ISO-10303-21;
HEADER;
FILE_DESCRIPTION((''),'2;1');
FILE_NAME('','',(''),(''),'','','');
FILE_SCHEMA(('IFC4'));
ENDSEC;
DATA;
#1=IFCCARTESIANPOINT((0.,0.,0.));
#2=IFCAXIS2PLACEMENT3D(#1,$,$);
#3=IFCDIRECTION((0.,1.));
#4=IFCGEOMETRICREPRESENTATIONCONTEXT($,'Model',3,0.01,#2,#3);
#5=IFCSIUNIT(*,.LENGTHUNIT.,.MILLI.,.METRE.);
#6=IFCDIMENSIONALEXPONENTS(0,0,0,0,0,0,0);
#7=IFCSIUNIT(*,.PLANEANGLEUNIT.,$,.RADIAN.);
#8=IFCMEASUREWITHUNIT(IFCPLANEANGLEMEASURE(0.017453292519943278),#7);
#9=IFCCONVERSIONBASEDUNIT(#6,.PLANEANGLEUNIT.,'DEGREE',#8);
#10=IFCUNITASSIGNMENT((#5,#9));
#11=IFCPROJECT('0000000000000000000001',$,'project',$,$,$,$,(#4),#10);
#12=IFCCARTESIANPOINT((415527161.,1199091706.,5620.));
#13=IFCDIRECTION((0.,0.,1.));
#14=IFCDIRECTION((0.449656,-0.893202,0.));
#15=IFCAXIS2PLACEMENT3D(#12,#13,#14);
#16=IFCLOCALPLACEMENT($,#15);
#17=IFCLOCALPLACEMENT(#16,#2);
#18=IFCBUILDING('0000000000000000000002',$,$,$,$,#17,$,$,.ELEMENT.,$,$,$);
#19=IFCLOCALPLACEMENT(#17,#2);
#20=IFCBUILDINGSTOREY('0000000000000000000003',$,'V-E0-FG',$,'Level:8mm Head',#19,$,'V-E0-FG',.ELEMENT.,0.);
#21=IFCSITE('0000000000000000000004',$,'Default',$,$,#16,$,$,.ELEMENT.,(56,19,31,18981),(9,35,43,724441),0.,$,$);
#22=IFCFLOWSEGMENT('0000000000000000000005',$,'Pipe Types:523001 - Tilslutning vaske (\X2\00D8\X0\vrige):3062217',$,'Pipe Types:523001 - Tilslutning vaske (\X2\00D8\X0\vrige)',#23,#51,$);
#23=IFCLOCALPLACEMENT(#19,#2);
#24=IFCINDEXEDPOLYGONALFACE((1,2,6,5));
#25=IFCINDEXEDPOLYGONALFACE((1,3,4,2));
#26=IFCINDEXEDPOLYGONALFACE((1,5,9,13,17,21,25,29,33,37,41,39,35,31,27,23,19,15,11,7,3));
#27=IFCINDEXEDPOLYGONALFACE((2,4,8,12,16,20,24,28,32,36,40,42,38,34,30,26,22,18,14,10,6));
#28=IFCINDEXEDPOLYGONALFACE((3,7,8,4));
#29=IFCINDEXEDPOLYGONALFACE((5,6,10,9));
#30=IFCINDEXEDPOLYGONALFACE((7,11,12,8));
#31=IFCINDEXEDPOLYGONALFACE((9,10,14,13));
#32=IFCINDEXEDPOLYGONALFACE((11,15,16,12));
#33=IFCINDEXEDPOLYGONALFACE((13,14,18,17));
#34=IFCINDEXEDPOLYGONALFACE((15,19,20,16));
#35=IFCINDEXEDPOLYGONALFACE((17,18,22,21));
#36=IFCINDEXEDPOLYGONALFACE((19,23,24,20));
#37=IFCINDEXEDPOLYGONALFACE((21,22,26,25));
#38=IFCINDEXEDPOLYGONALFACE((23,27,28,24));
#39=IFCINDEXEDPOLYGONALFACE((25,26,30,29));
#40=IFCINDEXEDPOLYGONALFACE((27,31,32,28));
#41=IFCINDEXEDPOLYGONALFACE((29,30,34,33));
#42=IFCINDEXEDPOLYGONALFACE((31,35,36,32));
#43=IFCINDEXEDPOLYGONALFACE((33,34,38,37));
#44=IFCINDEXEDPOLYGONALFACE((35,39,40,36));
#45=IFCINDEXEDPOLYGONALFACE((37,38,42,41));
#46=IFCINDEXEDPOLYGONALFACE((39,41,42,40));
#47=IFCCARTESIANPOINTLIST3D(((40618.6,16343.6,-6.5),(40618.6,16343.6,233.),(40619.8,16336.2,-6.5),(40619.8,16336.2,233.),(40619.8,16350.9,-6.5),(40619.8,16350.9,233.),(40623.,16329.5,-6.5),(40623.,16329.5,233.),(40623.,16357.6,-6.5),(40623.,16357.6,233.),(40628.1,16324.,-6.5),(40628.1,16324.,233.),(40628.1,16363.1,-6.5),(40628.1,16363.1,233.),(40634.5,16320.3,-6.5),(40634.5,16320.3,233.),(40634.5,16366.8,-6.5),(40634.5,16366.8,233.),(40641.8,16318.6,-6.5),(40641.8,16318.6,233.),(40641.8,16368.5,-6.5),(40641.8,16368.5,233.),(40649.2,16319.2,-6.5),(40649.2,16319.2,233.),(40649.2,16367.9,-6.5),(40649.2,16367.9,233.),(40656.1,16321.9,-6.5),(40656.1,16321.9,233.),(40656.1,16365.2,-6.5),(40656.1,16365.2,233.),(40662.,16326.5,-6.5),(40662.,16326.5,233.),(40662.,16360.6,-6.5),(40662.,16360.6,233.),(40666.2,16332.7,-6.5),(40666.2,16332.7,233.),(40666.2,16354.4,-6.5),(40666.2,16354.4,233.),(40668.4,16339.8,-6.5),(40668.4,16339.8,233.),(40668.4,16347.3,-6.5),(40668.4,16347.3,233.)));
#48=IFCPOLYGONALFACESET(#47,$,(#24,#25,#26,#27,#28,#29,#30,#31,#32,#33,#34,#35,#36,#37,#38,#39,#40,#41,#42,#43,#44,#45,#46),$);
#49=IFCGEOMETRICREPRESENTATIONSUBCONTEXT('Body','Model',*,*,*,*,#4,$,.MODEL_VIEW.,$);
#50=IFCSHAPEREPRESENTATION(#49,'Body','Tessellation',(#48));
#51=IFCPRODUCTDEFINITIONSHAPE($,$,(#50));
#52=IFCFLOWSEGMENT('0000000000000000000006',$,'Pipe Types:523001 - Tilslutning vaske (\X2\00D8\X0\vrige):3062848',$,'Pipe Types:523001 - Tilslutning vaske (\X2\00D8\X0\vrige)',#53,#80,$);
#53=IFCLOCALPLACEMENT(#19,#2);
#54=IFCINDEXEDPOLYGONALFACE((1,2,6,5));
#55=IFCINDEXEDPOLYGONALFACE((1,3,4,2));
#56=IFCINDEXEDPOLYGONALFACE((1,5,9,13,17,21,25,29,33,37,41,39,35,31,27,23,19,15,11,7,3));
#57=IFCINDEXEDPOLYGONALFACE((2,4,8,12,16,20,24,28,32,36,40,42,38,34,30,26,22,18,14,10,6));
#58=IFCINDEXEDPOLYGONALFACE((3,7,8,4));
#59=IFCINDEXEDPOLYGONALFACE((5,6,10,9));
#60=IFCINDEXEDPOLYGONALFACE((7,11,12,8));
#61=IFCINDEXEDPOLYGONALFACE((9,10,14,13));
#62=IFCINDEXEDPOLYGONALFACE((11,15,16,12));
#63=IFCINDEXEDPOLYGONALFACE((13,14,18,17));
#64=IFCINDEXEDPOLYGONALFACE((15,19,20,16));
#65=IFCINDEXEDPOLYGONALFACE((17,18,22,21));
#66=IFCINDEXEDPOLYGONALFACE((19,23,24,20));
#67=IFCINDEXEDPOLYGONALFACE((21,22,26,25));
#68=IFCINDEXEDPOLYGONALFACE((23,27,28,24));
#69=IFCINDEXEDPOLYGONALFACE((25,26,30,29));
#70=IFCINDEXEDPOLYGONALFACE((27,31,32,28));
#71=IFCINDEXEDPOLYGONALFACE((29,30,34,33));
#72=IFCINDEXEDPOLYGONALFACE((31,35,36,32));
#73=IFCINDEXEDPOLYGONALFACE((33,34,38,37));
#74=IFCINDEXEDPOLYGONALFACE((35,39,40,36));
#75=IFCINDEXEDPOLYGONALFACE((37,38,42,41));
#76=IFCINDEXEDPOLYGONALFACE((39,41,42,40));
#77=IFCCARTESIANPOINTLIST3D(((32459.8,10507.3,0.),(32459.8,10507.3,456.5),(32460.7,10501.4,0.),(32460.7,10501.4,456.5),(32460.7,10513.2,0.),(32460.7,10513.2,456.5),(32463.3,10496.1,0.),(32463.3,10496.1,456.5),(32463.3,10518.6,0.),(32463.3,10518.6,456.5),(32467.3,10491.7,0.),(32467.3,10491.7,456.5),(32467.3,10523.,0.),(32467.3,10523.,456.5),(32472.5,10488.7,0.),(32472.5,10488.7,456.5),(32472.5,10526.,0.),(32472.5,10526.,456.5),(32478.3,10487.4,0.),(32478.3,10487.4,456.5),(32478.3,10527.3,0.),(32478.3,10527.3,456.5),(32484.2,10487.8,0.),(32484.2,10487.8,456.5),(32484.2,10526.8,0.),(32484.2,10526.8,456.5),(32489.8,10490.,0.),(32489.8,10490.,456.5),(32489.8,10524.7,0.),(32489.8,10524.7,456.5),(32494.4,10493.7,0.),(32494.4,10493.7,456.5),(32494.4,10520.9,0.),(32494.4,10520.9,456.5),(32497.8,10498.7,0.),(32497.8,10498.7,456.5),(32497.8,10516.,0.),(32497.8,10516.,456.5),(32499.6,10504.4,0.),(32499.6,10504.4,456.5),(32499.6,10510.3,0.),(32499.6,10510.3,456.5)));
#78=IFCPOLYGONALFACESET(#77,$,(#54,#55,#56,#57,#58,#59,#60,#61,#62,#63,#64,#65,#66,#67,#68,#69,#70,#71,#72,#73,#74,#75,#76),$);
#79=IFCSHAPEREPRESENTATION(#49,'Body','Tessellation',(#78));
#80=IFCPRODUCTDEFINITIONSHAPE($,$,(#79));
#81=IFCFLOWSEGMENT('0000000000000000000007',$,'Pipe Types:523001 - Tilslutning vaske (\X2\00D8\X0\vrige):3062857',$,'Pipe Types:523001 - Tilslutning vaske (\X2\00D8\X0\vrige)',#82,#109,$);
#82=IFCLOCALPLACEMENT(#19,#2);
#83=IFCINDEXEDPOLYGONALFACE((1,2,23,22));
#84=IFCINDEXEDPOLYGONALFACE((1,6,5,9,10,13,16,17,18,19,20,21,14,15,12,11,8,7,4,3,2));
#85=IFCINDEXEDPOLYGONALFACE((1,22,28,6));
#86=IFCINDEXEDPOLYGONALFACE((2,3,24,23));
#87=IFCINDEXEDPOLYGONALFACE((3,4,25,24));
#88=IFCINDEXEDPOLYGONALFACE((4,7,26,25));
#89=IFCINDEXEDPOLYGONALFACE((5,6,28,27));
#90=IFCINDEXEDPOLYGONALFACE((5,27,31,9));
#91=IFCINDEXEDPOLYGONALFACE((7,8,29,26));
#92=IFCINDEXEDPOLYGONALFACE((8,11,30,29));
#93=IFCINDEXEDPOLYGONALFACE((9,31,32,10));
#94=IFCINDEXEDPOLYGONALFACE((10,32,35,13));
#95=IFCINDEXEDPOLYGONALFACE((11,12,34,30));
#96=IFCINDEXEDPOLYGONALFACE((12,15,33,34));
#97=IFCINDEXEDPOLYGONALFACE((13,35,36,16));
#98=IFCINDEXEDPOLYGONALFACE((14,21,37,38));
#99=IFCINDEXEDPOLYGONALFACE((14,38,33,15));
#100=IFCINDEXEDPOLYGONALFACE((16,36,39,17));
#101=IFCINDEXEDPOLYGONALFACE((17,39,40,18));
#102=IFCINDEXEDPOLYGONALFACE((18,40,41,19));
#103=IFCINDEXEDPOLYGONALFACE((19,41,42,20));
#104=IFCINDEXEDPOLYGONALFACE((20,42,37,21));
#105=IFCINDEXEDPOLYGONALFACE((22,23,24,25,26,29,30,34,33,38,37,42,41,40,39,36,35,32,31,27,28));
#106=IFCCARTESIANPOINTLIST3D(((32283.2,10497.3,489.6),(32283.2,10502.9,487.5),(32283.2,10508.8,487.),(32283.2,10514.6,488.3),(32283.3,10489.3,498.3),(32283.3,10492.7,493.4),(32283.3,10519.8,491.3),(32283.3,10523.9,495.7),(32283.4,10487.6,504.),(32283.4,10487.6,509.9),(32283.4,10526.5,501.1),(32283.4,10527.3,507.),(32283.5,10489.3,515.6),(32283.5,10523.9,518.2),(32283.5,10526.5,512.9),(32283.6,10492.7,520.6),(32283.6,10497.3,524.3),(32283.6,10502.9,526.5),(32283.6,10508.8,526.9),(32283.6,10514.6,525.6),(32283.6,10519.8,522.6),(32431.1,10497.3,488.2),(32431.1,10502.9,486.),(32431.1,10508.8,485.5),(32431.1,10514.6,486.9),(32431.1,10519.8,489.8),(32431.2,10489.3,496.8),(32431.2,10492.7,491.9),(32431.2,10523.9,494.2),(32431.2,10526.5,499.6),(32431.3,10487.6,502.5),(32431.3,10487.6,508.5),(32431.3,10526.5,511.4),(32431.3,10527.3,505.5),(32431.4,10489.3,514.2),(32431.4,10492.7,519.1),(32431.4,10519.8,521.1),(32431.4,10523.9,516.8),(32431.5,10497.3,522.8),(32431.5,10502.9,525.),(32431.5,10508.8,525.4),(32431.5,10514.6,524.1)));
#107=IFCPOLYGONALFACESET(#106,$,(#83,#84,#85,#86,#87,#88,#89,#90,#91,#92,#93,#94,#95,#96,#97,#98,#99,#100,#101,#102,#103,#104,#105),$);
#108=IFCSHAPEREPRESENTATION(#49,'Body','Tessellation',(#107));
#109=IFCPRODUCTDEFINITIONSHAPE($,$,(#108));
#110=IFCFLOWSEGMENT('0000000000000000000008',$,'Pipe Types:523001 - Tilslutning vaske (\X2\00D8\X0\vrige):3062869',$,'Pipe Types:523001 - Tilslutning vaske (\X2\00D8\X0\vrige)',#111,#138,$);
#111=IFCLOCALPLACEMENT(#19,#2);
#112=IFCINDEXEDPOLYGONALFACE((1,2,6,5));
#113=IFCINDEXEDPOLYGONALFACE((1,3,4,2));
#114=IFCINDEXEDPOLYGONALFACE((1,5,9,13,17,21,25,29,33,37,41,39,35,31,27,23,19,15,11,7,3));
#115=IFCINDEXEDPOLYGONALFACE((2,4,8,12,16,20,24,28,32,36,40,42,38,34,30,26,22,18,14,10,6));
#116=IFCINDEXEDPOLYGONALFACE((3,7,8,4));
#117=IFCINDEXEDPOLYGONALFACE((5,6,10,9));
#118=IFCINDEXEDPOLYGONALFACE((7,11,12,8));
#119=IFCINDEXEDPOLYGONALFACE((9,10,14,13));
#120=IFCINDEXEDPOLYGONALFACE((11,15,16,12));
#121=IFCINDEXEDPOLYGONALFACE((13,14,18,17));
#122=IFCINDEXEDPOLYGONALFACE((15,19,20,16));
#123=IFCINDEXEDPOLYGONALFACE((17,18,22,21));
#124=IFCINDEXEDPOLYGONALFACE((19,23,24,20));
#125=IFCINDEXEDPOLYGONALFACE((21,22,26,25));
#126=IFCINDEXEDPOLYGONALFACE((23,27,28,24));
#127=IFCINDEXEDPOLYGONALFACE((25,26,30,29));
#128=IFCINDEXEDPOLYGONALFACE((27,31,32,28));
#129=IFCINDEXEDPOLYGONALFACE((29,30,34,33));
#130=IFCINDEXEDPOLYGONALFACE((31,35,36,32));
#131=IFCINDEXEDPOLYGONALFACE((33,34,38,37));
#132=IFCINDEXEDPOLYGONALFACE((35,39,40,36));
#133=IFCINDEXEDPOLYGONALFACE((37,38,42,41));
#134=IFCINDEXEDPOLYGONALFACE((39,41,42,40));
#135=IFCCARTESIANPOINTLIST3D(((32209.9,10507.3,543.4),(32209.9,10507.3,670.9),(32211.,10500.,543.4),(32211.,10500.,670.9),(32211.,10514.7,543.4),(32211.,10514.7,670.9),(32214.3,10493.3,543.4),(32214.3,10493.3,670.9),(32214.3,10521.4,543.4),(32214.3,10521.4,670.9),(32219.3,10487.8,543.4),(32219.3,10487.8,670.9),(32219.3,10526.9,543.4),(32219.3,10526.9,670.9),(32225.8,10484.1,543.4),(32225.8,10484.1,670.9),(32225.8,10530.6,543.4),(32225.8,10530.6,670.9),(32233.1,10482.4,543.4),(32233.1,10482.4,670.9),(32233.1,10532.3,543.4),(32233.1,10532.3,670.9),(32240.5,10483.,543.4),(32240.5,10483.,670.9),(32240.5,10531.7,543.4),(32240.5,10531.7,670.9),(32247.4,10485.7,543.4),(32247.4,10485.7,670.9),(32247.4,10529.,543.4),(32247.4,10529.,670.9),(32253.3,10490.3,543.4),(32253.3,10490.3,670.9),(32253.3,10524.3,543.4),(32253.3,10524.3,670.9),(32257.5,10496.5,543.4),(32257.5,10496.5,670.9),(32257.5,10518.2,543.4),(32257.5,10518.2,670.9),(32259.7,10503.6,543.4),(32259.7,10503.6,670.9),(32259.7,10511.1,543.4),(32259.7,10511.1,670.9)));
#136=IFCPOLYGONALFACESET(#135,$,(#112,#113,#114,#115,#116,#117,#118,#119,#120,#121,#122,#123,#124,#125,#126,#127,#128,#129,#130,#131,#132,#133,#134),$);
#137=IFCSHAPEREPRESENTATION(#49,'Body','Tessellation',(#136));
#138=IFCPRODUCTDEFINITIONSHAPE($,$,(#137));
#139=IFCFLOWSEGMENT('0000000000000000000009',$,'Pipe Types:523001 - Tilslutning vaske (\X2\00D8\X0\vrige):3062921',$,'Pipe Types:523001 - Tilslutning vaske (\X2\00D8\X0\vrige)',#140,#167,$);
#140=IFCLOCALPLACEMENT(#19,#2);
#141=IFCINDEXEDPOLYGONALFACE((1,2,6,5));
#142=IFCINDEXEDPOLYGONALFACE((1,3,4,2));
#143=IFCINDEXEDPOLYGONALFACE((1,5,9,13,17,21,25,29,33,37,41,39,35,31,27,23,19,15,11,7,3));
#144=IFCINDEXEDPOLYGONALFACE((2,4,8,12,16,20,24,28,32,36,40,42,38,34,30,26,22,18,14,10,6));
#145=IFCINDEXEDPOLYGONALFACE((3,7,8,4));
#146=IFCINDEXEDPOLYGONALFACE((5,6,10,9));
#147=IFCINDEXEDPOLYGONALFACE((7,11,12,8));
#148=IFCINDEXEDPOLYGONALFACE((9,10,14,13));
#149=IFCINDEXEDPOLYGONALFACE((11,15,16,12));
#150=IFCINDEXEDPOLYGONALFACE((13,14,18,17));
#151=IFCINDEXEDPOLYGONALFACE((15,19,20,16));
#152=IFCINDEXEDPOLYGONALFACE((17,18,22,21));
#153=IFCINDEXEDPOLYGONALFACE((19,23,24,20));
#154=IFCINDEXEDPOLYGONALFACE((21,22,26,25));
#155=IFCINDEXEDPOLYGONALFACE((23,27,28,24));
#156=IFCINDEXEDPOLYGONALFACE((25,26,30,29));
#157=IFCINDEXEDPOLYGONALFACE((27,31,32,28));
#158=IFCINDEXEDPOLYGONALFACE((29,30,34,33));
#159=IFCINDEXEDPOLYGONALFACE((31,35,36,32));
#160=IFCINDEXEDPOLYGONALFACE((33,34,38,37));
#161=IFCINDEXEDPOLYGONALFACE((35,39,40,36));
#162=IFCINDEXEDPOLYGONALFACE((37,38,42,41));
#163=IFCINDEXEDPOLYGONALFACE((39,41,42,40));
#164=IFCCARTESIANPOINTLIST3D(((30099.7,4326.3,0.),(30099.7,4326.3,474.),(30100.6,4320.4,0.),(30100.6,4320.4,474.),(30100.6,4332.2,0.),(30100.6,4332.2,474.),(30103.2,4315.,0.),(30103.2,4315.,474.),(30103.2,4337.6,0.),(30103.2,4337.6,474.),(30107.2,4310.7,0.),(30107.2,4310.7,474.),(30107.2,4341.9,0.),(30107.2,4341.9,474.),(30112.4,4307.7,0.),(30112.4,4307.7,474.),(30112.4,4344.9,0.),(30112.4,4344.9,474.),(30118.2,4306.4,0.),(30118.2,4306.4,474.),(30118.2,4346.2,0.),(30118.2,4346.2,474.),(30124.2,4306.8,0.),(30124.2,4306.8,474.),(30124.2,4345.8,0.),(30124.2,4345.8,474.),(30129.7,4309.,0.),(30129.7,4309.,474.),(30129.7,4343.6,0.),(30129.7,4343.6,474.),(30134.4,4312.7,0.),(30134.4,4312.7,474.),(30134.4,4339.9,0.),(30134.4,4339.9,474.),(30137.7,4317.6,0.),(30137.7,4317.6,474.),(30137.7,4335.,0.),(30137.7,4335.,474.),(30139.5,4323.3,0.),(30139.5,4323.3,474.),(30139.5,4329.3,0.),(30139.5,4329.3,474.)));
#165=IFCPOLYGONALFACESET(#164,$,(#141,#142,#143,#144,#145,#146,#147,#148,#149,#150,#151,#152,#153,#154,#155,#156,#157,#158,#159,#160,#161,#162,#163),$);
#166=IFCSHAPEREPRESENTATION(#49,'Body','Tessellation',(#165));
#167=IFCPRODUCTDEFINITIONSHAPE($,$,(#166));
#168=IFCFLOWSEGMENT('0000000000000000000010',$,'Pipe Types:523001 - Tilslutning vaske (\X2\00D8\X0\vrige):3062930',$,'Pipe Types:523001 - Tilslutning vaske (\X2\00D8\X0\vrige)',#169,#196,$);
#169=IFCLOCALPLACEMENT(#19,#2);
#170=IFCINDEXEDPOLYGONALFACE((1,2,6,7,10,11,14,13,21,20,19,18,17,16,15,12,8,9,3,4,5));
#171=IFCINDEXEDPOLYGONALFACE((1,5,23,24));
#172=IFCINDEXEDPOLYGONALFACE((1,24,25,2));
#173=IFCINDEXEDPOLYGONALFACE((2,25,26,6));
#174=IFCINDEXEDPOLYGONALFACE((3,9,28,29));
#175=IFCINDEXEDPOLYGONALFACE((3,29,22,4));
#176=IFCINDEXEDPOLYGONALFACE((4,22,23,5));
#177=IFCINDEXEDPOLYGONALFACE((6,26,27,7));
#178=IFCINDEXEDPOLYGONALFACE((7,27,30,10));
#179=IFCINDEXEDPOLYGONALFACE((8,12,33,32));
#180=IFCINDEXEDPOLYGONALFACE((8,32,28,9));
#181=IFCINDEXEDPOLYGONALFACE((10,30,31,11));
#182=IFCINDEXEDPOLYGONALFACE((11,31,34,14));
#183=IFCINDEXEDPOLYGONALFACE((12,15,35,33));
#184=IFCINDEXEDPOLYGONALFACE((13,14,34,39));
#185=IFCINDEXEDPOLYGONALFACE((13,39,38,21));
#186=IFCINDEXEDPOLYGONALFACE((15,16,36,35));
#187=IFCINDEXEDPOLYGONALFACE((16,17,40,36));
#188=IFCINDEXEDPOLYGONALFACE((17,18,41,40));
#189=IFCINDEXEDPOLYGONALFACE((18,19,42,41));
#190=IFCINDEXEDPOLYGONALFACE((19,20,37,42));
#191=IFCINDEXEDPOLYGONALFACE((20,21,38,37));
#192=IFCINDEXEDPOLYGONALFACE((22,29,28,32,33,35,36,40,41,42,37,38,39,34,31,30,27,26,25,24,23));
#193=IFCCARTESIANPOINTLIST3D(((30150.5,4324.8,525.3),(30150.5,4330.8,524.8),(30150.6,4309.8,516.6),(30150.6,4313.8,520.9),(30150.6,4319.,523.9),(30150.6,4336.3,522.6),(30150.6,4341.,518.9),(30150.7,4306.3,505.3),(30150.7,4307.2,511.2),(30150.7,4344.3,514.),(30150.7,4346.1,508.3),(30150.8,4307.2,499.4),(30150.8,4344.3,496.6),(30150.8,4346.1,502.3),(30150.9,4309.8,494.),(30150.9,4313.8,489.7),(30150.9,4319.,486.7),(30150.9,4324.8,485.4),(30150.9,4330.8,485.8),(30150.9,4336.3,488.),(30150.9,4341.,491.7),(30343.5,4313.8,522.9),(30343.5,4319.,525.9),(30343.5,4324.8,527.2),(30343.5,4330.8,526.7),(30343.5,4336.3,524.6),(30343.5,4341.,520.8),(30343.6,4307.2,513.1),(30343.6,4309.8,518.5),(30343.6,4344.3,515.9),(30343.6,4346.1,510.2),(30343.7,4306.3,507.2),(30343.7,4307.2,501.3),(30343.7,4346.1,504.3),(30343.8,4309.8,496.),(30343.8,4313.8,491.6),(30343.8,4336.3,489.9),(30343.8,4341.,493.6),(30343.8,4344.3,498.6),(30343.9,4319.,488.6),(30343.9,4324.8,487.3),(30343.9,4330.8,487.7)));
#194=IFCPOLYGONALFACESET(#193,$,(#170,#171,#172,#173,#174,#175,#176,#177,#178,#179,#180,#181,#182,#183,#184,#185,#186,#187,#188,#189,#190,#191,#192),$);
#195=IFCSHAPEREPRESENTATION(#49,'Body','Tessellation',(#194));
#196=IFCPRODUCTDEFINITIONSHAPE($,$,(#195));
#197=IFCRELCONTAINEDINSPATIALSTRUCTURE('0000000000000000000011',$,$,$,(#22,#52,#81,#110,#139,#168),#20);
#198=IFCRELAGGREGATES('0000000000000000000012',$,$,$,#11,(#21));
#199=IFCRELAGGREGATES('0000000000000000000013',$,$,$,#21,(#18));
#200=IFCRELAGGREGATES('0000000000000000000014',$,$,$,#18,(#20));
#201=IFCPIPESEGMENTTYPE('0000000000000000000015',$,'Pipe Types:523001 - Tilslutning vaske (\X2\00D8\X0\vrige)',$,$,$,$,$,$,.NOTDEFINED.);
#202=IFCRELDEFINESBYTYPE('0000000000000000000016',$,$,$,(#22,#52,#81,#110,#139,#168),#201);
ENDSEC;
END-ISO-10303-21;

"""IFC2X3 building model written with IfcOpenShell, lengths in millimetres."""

from ifc_helpers import new_model, entity, si_unit, converted_unit, direction, frame, frame_2d, origin, origin_2d_with_axis, place, context, subcontext, project, spatial, circle, extrude, type_object, element, save


model = new_model("IFC2X3")

# Units and contexts
model_context = context("Model", 3, precision=0.01, world=origin(), true_north=direction((0.0, 1.0)))
body_context = subcontext(model_context, "Body", "Model", "MODEL_VIEW")
ifc_project = project(units=[si_unit("LENGTHUNIT", "METRE", prefix="MILLI"), converted_unit("PLANEANGLEUNIT", "DEGREE", entity("IfcPlaneAngleMeasure", 0.017453292519943278), si_unit("PLANEANGLEUNIT", "RADIAN"), dimensions=[0, 0, 0, 0, 0, 0, 0])], contexts=[model_context])

# Site, building, storey
site_placement = place(None, frame((415527161.0, 1199091706.0, 5620.0), z_axis=(0.0, 0.0, 1.0), x_axis=(0.449656, -0.893202, 0.0)))
site = spatial("IfcSite", under=ifc_project, at=site_placement, Name="Default", CompositionType="ELEMENT", RefLatitude=(56, 19, 31, 18981), RefLongitude=(9, 35, 43, 724441), RefElevation=0.0)
building_placement = place(site_placement, origin())
building = spatial("IfcBuilding", under=site, at=building_placement, CompositionType="ELEMENT")
storey_placement = place(building_placement, origin())
storey = spatial("IfcBuildingStorey", under=building, at=storey_placement, Name="V-E0-FG", ObjectType="Level:8mm Head", LongName="V-E0-FG", CompositionType="ELEMENT", Elevation=0.0)

# Flow segments
pipe_segment_type_1 = type_object("IfcPipeSegmentType", Name="Pipe Types:523001 - Tilslutning vaske (Øvrige)", PredefinedType="NOTDEFINED")
flow_segment_1_placement = place(storey_placement, origin())
element("IfcFlowSegment", 1, at=flow_segment_1_placement, inside=storey, type_object=pipe_segment_type_1, Name="Pipe Types:523001 - Tilslutning vaske (Øvrige):3062217", ObjectType="Pipe Types:523001 - Tilslutning vaske (Øvrige)", context=body_context, shape_type="SweptSolid", body=[
    extrude(circle(Radius=25.0, at=origin_2d_with_axis()), frame((40643.6, 16343.6, -6.5), z_axis=(0.0, 0.0, 1.0), x_axis=(-1.0, 0.0, 0.0)), (0.0, 0.0, 1.0), 239.4),
])
flow_segment_2_placement = place(storey_placement, origin())
element("IfcFlowSegment", 2, at=flow_segment_2_placement, inside=storey, type_object=pipe_segment_type_1, Name="Pipe Types:523001 - Tilslutning vaske (Øvrige):3062848", ObjectType="Pipe Types:523001 - Tilslutning vaske (Øvrige)", context=body_context, shape_type="SweptSolid", body=[
    extrude(circle(Radius=20.0, at=origin_2d_with_axis()), frame((32479.8, 10507.3, 0.0), z_axis=(0.0, 0.0, 1.0), x_axis=(-1.0, 0.0, 0.0)), (0.0, 0.0, 1.0), 456.5),
])
flow_segment_3_placement = place(storey_placement, origin())
element("IfcFlowSegment", 3, at=flow_segment_3_placement, inside=storey, type_object=pipe_segment_type_1, Name="Pipe Types:523001 - Tilslutning vaske (Øvrige):3062857", ObjectType="Pipe Types:523001 - Tilslutning vaske (Øvrige)", context=body_context, shape_type="SweptSolid", body=[
    extrude(circle(Radius=20.0, at=frame_2d((0.0, 0.0), x_axis=(1.0, 0.0))), frame((32283.4, 10507.3, 507.0), z_axis=(0.99995, 0.0, -0.01), x_axis=(0.0, 1.0, 0.0)), (0.0, 0.0, 1.0), 147.9),
])
flow_segment_4_placement = place(storey_placement, origin())
element("IfcFlowSegment", 4, at=flow_segment_4_placement, inside=storey, type_object=pipe_segment_type_1, Name="Pipe Types:523001 - Tilslutning vaske (Øvrige):3062869", ObjectType="Pipe Types:523001 - Tilslutning vaske (Øvrige)", context=body_context, shape_type="SweptSolid", body=[
    extrude(circle(Radius=25.0, at=origin_2d_with_axis()), frame((32234.9, 10507.3, 543.4), z_axis=(0.0, 0.0, 1.0), x_axis=(-1.0, 0.0, 0.0)), (0.0, 0.0, 1.0), 127.4),
])
flow_segment_5_placement = place(storey_placement, origin())
element("IfcFlowSegment", 5, at=flow_segment_5_placement, inside=storey, type_object=pipe_segment_type_1, Name="Pipe Types:523001 - Tilslutning vaske (Øvrige):3062921", ObjectType="Pipe Types:523001 - Tilslutning vaske (Øvrige)", context=body_context, shape_type="SweptSolid", body=[
    extrude(circle(Radius=20.0, at=origin_2d_with_axis()), frame((30119.7, 4326.3, 0.0), z_axis=(0.0, 0.0, 1.0), x_axis=(-1.0, 0.0, 0.0)), (0.0, 0.0, 1.0), 474.0),
])
flow_segment_6_placement = place(storey_placement, origin())
element("IfcFlowSegment", 6, at=flow_segment_6_placement, inside=storey, type_object=pipe_segment_type_1, Name="Pipe Types:523001 - Tilslutning vaske (Øvrige):3062930", ObjectType="Pipe Types:523001 - Tilslutning vaske (Øvrige)", context=body_context, shape_type="SweptSolid", body=[
    extrude(circle(Radius=20.0, at=frame_2d((0.0, 0.0), x_axis=(1.0, 0.0))), frame((30150.7, 4326.3, 505.3), z_axis=(0.99995, 0.0, 0.01), x_axis=(0.0, -1.0, 0.0)), (0.0, 0.0, 1.0), 192.9),
])

save(model, "model.ifc")
